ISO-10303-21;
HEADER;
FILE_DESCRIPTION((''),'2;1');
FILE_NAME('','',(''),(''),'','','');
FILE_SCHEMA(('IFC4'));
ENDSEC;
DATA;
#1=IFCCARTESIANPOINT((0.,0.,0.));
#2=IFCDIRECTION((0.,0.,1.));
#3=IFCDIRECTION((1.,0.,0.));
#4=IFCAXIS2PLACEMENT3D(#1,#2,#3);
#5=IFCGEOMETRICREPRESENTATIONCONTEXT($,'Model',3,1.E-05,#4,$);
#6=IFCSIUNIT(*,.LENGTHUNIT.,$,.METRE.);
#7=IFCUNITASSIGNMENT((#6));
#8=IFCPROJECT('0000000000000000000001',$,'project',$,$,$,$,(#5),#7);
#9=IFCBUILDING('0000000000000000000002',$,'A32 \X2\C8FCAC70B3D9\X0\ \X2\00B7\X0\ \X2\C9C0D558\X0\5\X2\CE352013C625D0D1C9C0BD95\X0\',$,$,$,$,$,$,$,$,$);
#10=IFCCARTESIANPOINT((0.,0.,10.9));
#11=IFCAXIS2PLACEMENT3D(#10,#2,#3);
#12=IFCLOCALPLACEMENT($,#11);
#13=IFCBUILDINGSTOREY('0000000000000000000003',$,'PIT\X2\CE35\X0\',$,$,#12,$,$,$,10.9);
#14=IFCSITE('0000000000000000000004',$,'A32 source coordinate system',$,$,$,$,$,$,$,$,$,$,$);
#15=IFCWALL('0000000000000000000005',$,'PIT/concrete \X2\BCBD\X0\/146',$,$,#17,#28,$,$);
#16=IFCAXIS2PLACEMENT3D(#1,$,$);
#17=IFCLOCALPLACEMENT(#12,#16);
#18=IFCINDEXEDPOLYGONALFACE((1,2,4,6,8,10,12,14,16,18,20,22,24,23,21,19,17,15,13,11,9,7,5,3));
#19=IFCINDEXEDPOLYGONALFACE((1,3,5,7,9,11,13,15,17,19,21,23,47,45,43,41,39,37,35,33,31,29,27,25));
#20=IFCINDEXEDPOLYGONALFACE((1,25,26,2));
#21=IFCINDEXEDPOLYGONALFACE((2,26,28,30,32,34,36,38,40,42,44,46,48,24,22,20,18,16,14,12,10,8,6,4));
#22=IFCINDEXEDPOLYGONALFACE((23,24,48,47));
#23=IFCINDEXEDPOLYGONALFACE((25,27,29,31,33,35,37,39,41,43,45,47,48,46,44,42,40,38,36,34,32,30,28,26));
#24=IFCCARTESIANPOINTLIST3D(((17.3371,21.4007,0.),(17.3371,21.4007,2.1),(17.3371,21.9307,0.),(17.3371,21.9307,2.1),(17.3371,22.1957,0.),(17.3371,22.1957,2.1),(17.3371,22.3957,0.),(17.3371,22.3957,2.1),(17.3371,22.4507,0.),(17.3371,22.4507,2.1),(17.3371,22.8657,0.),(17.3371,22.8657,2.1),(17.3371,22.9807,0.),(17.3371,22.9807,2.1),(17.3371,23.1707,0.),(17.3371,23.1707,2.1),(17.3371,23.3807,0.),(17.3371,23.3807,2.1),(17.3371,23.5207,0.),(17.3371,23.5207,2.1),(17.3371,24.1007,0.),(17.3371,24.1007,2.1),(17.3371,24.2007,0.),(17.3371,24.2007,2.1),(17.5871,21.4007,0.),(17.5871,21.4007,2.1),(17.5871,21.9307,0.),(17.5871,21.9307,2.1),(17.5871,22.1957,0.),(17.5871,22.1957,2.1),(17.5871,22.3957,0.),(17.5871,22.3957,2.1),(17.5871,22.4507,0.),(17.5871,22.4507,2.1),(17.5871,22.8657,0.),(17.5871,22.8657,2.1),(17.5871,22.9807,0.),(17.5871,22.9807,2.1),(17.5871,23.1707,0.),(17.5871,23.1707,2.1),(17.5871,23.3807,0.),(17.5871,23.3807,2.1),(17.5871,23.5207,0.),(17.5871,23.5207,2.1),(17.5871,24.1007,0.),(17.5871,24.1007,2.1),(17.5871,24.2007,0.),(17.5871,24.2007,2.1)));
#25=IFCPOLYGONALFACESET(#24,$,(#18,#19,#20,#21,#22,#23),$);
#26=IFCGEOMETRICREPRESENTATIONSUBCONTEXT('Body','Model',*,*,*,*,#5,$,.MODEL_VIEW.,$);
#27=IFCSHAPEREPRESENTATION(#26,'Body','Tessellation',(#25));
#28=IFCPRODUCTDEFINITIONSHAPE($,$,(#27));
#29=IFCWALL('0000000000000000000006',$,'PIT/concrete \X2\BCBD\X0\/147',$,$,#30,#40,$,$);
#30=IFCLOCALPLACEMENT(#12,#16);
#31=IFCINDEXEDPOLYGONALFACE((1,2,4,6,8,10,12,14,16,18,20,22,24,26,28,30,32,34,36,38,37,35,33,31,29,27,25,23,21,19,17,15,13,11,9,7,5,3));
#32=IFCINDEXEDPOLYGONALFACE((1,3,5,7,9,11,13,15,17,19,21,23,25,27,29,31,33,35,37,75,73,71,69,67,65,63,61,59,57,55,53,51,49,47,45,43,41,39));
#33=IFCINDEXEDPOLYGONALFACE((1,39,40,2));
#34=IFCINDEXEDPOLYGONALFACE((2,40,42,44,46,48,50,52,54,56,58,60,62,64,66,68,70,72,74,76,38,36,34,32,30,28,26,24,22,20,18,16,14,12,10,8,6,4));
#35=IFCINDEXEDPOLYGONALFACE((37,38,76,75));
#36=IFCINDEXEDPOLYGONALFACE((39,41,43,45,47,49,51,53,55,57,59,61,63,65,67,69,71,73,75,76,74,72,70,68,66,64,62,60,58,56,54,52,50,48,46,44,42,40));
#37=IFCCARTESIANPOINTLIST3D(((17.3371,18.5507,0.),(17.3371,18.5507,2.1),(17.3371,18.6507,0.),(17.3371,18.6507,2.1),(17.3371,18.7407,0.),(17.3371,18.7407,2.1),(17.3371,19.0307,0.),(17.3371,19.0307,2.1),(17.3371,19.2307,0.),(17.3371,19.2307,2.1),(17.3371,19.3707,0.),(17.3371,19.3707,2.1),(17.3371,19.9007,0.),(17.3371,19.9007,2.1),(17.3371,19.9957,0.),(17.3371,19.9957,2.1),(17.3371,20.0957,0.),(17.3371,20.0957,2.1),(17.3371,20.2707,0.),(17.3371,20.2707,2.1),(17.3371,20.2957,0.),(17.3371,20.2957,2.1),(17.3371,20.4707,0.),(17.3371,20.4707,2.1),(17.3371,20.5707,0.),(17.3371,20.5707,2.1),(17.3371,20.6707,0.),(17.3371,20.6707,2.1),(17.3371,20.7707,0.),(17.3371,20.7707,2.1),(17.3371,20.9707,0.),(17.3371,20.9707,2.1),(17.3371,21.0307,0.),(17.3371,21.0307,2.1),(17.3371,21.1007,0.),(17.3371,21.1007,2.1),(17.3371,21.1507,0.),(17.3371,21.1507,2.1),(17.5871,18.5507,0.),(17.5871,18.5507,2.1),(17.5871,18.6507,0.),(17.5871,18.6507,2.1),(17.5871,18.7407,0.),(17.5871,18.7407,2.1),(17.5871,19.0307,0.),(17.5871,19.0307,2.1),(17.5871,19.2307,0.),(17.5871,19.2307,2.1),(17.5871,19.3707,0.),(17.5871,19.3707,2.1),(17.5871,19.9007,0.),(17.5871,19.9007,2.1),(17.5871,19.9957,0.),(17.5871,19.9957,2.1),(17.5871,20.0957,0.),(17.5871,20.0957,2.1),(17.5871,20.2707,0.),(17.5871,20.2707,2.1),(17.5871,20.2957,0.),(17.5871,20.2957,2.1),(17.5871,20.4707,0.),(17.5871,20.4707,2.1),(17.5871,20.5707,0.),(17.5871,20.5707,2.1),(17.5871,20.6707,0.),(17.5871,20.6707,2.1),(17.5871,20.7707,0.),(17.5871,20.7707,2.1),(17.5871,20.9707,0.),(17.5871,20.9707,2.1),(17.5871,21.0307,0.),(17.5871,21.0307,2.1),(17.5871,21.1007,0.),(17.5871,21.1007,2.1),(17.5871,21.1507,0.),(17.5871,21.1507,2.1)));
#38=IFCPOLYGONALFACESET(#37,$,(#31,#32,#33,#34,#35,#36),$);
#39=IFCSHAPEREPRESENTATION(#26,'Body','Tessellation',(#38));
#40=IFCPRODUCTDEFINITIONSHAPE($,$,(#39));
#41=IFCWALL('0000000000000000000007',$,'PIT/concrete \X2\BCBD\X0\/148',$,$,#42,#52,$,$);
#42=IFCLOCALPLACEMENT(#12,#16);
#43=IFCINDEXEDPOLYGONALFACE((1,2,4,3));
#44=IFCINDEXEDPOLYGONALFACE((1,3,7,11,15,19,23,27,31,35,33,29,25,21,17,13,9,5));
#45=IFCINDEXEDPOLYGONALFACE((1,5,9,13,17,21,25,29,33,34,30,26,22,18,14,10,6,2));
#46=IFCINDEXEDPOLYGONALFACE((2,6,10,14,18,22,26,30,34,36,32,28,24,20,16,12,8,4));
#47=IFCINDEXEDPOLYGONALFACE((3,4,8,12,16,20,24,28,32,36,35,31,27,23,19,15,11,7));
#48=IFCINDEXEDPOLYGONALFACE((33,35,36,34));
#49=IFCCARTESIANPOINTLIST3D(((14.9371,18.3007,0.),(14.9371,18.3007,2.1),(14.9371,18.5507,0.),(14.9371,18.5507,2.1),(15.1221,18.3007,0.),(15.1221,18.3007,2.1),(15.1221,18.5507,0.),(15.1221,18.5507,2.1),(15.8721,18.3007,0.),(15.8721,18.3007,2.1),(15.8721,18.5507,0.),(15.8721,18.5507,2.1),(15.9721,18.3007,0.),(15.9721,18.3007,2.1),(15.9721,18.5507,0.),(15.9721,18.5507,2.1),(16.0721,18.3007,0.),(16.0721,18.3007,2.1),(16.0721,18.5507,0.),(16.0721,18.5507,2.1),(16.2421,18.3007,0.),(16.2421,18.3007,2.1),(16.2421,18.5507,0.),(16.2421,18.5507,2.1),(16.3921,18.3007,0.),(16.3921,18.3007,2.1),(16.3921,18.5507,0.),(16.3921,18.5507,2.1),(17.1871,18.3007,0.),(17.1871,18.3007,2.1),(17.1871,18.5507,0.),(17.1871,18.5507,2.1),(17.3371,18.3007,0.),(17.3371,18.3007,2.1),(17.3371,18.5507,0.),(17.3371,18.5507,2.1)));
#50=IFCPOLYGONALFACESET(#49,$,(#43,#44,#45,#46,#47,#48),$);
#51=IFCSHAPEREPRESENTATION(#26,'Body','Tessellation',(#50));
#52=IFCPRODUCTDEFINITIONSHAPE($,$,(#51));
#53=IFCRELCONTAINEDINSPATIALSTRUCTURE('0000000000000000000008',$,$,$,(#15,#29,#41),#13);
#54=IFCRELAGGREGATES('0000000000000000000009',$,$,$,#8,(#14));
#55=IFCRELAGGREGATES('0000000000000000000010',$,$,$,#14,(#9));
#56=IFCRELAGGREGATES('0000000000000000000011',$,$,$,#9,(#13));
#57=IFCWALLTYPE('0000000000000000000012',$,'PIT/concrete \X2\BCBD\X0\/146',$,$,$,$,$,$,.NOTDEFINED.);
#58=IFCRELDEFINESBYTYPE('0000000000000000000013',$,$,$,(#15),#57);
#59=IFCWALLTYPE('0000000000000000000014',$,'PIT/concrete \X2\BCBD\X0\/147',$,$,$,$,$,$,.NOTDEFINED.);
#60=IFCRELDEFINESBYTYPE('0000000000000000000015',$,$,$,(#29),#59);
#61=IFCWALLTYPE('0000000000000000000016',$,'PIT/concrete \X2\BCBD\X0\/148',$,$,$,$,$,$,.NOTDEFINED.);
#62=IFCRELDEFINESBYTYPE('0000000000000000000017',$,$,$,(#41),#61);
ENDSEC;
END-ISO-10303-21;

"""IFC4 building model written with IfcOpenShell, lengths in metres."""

from ifc_helpers import new_model, si_unit, frame, origin, origin_with_axes, place, context, subcontext, project, spatial, polyline, outline, extrude, source, transform, mapped, type_object, type_shapes, element, save


model = new_model("IFC4")

# Units and contexts
model_context = context("Model", 3, precision=1e-05, world=origin_with_axes())
body_context = subcontext(model_context, "Body", "Model", "MODEL_VIEW")
ifc_project = project(units=[si_unit("LENGTHUNIT", "METRE")], contexts=[model_context])

# Site, building, storey
site = spatial("IfcSite", under=ifc_project, Name="A32 source coordinate system")
building = spatial("IfcBuilding", under=site, Name="A32 주거동 · 지하5층–옥탑지붕")
storey_placement = place(None, frame((0.0, 0.0, 10.9), z_axis=(0.0, 0.0, 1.0), x_axis=(1.0, 0.0, 0.0)))
storey = spatial("IfcBuildingStorey", under=building, at=storey_placement, Name="PIT층", Elevation=10.9)

# Walls
wall_type_1 = type_object("IfcWallType", Name="PIT/concrete 벽/146", PredefinedType="NOTDEFINED")
shared_shape_1 = source(origin(), body_context, "Body", "SweptSolid", [
    extrude(outline(polyline([(17.5871, 23.5207), (17.5871, 23.3807), (17.5871, 23.1707), (17.5871, 22.9807), (17.5871, 22.8657), (17.5871, 22.4507), (17.5871, 22.3957), (17.5871, 22.1957), (17.5871, 21.9307), (17.5871, 21.4007), (17.3371, 21.4007), (17.3371, 21.9307), (17.3371, 22.1957), (17.3371, 22.3957), (17.3371, 22.4507), (17.3371, 22.8657), (17.3371, 22.9807), (17.3371, 23.1707), (17.3371, 23.3807), (17.3371, 23.5207), (17.3371, 24.1007), (17.3371, 24.2007), (17.5871, 24.2007), (17.5871, 24.1007), (17.5871, 23.5207)])), origin(), (0.0, 0.0, 1.0), 2.1),
])
type_shapes(wall_type_1, [shared_shape_1])
wall_1_placement = place(storey_placement, origin_with_axes())
element("IfcWall", 1, at=wall_1_placement, inside=storey, type_object=wall_type_1, Name="PIT/concrete 벽/146", context=body_context, shape_type="MappedRepresentation", body=[
    mapped(shared_shape_1, transform((0.0, 0.0, 0.0), scale=1.0)),
])
wall_type_2 = type_object("IfcWallType", Name="PIT/concrete 벽/147", PredefinedType="NOTDEFINED")
shared_shape_2 = source(origin(), body_context, "Body", "SweptSolid", [
    extrude(outline(polyline([(17.5871, 21.0307), (17.5871, 20.9707), (17.5871, 20.7707), (17.5871, 20.6707), (17.5871, 20.5707), (17.5871, 20.4707), (17.5871, 20.2957), (17.5871, 20.2707), (17.5871, 20.0957), (17.5871, 19.9957), (17.5871, 19.9007), (17.5871, 19.3707), (17.5871, 19.2307), (17.5871, 19.0307), (17.5871, 18.7407), (17.5871, 18.6507), (17.5871, 18.5507), (17.3371, 18.5507), (17.3371, 18.6507), (17.3371, 18.7407), (17.3371, 19.0307), (17.3371, 19.2307), (17.3371, 19.3707), (17.3371, 19.9007), (17.3371, 19.9957), (17.3371, 20.0957), (17.3371, 20.2707), (17.3371, 20.2957), (17.3371, 20.4707), (17.3371, 20.5707), (17.3371, 20.6707), (17.3371, 20.7707), (17.3371, 20.9707), (17.3371, 21.0307), (17.3371, 21.1007), (17.3371, 21.1507), (17.5871, 21.1507), (17.5871, 21.1007), (17.5871, 21.0307)])), origin(), (0.0, 0.0, 1.0), 2.1),
])
type_shapes(wall_type_2, [shared_shape_2])
wall_2_placement = place(storey_placement, origin_with_axes())
element("IfcWall", 2, at=wall_2_placement, inside=storey, type_object=wall_type_2, Name="PIT/concrete 벽/147", context=body_context, shape_type="MappedRepresentation", body=[
    mapped(shared_shape_2, transform((0.0, 0.0, 0.0), scale=1.0)),
])
wall_type_3 = type_object("IfcWallType", Name="PIT/concrete 벽/148", PredefinedType="NOTDEFINED")
shared_shape_3 = source(origin(), body_context, "Body", "SweptSolid", [
    extrude(outline(polyline([(16.3921, 18.3007), (16.2421, 18.3007), (16.0721, 18.3007), (15.9721, 18.3007), (15.8721, 18.3007), (15.1221, 18.3007), (14.9371, 18.3007), (14.9371, 18.5507), (15.1221, 18.5507), (15.8721, 18.5507), (15.9721, 18.5507), (16.0721, 18.5507), (16.2421, 18.5507), (16.3921, 18.5507), (17.1871, 18.5507), (17.3371, 18.5507), (17.3371, 18.3007), (17.1871, 18.3007), (16.3921, 18.3007)])), origin(), (0.0, 0.0, 1.0), 2.1),
])
type_shapes(wall_type_3, [shared_shape_3])
wall_3_placement = place(storey_placement, origin_with_axes())
element("IfcWall", 3, at=wall_3_placement, inside=storey, type_object=wall_type_3, Name="PIT/concrete 벽/148", context=body_context, shape_type="MappedRepresentation", body=[
    mapped(shared_shape_3, transform((0.0, 0.0, 0.0), scale=1.0)),
])

save(model, "model.ifc")
